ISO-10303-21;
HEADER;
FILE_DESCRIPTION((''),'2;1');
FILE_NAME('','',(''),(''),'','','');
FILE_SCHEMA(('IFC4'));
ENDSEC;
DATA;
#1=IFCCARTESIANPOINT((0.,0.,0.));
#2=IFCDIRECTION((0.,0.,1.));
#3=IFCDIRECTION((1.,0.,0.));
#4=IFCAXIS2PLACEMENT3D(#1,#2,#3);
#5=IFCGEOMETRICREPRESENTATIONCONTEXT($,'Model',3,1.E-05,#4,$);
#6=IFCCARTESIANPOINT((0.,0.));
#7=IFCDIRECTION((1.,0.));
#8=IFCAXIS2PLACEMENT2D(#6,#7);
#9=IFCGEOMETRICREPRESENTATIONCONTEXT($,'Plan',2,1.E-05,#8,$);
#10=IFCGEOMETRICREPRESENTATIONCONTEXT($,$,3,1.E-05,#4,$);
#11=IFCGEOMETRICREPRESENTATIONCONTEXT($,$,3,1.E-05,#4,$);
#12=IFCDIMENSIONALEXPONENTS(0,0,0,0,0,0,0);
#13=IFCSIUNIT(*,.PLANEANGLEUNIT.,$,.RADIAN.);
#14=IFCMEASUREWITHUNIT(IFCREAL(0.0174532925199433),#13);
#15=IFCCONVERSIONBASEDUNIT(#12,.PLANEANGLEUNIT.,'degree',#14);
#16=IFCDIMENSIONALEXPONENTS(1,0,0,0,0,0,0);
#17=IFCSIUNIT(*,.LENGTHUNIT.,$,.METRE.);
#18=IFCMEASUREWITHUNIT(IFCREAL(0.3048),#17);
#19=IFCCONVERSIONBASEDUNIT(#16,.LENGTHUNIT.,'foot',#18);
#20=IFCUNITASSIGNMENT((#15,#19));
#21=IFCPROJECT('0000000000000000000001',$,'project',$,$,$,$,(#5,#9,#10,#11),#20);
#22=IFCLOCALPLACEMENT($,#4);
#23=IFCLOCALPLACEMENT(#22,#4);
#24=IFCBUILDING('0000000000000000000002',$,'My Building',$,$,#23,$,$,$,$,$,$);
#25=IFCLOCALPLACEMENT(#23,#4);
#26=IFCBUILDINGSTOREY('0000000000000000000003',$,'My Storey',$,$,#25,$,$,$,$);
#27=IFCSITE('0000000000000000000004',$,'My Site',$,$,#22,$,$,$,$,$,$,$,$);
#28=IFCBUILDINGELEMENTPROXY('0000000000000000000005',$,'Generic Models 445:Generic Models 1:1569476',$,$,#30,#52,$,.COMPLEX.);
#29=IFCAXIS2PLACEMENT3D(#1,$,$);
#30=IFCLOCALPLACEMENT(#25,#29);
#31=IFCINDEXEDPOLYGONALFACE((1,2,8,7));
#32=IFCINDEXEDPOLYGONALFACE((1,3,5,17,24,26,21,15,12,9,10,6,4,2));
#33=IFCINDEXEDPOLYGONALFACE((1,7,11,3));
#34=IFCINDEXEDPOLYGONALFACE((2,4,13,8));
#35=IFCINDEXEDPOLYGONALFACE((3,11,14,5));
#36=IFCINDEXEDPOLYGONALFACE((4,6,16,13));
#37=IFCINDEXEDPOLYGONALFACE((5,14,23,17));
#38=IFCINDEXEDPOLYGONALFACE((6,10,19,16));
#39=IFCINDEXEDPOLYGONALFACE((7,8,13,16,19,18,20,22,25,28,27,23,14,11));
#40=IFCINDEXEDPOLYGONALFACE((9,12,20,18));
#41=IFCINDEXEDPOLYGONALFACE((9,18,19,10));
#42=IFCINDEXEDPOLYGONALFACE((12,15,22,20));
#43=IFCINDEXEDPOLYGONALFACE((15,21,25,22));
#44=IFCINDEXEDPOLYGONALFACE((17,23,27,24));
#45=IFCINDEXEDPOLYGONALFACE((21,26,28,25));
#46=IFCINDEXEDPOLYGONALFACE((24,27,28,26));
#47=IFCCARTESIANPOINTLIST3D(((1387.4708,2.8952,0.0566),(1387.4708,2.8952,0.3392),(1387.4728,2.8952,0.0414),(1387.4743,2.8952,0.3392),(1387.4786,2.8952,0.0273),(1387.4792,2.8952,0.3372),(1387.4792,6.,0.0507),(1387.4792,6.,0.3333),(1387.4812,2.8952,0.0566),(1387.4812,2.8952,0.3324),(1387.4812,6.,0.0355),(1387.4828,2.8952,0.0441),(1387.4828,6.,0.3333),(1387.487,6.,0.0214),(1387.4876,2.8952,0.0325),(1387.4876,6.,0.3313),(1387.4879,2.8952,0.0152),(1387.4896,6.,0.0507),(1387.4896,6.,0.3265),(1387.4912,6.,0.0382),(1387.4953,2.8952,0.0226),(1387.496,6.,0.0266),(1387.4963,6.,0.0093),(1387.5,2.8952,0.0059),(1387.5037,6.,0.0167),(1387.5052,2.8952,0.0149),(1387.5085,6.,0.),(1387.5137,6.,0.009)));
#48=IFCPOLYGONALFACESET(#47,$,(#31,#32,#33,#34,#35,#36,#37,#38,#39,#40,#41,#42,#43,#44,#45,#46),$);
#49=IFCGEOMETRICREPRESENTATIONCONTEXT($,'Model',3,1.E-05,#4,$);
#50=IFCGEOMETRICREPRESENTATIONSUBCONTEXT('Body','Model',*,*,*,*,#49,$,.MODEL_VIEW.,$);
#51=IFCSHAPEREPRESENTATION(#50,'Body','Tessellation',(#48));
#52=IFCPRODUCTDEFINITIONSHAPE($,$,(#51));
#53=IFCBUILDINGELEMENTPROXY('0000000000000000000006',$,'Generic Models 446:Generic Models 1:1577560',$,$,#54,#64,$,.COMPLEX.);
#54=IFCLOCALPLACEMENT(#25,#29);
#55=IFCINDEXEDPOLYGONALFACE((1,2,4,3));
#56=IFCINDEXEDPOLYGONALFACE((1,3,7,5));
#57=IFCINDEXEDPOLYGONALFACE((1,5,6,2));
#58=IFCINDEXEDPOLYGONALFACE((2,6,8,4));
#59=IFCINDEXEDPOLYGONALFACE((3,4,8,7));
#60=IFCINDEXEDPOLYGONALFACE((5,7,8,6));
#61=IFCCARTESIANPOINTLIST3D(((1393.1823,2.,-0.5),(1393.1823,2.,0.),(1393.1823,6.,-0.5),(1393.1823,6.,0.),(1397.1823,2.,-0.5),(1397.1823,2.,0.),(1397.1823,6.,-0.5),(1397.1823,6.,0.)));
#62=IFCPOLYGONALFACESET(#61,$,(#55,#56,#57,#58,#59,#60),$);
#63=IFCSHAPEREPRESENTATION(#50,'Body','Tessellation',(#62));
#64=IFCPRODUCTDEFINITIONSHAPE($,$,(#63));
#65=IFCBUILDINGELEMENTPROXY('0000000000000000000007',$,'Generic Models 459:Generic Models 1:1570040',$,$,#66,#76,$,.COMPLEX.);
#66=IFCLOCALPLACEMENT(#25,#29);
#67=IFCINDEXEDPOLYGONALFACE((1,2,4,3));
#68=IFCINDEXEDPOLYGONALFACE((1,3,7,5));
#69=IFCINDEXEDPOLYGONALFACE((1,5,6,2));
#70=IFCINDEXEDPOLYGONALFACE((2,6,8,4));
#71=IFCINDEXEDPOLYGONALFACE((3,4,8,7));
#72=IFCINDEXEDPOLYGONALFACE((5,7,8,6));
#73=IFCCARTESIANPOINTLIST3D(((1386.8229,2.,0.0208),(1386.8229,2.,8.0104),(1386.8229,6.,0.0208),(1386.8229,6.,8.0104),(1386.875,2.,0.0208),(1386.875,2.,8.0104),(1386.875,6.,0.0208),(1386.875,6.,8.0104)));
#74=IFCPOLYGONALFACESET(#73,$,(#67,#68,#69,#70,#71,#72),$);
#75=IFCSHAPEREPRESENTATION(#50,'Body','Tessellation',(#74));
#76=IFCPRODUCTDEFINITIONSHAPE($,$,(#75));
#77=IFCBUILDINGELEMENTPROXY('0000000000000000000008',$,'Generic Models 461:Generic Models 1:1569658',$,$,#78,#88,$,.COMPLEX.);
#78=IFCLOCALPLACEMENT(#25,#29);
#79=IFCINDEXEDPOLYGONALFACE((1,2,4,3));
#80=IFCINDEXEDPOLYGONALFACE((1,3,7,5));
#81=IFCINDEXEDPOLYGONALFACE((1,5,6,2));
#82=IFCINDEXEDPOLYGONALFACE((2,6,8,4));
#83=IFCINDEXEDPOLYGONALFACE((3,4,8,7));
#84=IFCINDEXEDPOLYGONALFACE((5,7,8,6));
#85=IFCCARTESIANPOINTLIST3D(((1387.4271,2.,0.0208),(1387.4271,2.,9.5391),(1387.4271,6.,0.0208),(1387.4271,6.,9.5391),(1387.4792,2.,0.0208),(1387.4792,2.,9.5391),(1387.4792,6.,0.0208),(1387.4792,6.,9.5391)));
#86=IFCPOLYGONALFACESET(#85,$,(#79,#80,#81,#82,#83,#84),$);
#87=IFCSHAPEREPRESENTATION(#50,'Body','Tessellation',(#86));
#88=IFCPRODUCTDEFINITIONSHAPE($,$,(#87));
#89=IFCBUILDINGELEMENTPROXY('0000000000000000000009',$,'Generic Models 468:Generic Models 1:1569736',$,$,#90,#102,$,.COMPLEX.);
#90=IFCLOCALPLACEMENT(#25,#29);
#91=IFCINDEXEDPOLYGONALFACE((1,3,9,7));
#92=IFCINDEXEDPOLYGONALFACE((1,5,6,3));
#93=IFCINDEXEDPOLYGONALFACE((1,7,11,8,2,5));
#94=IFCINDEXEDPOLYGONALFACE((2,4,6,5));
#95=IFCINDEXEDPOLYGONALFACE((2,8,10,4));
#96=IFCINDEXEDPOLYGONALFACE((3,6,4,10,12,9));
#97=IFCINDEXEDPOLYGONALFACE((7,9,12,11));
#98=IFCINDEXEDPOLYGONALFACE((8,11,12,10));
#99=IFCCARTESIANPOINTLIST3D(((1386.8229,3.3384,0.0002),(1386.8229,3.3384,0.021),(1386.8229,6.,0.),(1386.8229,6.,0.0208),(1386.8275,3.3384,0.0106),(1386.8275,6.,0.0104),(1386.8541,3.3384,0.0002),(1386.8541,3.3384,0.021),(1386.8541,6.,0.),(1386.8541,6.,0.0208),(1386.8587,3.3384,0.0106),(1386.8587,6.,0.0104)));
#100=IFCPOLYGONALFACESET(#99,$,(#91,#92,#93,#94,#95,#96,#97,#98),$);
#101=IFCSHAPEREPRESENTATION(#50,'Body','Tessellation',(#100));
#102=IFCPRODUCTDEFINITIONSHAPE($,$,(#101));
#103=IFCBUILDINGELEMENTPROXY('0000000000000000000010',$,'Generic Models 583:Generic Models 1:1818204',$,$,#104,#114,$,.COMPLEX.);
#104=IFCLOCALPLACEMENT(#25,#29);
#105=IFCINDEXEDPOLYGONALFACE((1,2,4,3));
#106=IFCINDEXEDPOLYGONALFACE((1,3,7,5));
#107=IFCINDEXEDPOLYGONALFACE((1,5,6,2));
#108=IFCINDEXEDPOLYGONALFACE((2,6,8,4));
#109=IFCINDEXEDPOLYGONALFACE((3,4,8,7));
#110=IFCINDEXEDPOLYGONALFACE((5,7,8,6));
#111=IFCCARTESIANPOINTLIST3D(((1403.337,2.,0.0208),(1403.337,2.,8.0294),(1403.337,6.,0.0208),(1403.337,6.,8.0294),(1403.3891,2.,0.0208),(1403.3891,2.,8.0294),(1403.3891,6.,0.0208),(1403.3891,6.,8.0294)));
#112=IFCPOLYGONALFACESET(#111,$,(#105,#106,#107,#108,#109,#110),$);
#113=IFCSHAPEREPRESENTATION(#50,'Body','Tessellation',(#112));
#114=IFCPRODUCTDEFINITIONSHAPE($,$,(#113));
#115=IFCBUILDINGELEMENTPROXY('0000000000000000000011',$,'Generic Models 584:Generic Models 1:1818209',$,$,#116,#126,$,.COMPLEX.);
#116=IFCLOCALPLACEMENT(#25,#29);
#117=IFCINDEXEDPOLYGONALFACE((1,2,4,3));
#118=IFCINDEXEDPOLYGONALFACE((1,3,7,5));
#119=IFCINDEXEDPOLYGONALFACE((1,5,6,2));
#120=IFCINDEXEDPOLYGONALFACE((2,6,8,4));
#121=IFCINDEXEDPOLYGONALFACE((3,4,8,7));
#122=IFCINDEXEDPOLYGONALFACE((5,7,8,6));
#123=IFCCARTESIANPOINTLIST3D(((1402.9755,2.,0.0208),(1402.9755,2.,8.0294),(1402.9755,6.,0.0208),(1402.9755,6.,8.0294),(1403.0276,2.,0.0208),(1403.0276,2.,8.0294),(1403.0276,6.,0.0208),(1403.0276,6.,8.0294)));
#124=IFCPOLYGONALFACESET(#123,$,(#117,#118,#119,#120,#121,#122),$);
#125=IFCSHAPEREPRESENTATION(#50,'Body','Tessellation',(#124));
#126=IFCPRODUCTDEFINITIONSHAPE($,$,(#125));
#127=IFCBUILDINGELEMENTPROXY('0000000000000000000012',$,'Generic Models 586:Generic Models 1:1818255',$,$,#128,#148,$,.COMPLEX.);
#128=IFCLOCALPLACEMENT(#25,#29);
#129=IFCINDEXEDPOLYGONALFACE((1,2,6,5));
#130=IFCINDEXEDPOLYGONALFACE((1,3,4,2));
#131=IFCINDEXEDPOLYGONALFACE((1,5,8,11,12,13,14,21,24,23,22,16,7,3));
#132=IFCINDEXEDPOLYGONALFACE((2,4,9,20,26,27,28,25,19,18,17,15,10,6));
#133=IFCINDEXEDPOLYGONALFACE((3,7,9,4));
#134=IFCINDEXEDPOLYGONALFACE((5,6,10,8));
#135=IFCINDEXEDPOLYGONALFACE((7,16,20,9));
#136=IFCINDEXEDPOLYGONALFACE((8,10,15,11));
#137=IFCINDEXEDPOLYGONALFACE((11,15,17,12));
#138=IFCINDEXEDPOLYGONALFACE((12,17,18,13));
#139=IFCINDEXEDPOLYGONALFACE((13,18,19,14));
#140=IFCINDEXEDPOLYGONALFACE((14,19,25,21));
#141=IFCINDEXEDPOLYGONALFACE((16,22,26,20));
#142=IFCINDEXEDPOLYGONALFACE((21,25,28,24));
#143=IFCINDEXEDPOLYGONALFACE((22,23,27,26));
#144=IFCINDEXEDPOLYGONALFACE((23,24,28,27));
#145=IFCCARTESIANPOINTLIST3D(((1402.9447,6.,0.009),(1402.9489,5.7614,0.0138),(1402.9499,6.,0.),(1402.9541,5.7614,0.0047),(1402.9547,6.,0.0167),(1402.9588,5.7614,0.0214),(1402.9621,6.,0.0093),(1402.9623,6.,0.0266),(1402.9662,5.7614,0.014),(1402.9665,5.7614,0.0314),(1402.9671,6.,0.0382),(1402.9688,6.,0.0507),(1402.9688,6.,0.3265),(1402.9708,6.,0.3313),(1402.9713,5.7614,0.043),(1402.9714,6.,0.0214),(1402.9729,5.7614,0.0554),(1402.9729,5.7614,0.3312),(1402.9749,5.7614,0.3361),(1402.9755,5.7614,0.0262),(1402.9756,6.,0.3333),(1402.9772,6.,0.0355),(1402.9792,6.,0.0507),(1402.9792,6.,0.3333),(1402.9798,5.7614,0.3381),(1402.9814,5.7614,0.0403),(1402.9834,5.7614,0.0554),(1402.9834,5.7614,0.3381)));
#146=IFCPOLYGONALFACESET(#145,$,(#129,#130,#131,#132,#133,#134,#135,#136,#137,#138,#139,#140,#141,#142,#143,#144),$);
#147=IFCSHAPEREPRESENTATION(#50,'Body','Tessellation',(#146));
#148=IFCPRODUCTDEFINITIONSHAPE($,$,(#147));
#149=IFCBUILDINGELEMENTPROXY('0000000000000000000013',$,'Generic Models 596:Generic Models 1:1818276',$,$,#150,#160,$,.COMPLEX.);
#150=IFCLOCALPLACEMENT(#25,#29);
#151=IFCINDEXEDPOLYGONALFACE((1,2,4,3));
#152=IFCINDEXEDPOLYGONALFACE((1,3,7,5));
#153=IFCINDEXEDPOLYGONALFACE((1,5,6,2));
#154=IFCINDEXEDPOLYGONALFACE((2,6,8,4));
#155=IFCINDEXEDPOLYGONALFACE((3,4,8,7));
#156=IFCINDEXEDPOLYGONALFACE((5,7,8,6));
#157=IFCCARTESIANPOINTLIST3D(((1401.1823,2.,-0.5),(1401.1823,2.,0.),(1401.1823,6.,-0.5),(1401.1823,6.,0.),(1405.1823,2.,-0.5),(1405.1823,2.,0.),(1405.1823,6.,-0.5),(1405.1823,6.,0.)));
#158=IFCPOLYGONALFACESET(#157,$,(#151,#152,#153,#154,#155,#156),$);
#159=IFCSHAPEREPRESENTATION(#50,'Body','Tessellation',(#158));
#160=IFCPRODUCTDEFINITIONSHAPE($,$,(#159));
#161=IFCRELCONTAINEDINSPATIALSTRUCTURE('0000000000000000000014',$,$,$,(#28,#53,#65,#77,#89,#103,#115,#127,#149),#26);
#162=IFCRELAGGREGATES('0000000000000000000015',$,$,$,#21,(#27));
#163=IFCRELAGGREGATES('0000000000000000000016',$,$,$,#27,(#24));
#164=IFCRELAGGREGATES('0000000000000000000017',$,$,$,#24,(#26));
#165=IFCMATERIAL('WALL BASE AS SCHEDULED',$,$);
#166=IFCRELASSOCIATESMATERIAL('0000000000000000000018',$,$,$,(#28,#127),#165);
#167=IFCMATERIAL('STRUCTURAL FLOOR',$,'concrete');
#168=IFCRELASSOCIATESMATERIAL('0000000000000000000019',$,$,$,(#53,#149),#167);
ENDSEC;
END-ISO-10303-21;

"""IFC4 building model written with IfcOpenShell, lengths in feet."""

from ifc_helpers import new_model, entity, si_unit, converted_unit, frame, origin_with_axes, origin_2d_with_axis, place, context, subcontext, project, spatial, polyline, line, indexed_curve, outline, extrude, material, element, save


model = new_model("IFC4")

# Units and contexts
model_context_1 = context("Model", 3, precision=1e-05, world=origin_with_axes())
plan_context = context("Plan", 2, precision=1e-05, world=origin_2d_with_axis())
model_context_2 = context("Model", 3, precision=1e-05, world=origin_with_axes())
context_of_model_1 = context(None, 3, precision=1e-05, world=origin_with_axes())
context_of_model_2 = context(None, 3, precision=1e-05, world=origin_with_axes())
body_context_1 = subcontext(model_context_2, "Body", "Model", "MODEL_VIEW")
ifc_project = project(units=[converted_unit("PLANEANGLEUNIT", "degree", entity("IfcReal", 0.0174532925199433), si_unit("PLANEANGLEUNIT", "RADIAN"), dimensions=[0, 0, 0, 0, 0, 0, 0]), converted_unit("LENGTHUNIT", "foot", entity("IfcReal", 0.3048), si_unit("LENGTHUNIT", "METRE"), dimensions=[1, 0, 0, 0, 0, 0, 0])], contexts=[model_context_1, plan_context, context_of_model_1, context_of_model_2])

# Site, building, storey
site_placement = place(None, origin_with_axes())
site = spatial("IfcSite", under=ifc_project, at=site_placement, Name="My Site")
building_placement = place(site_placement, origin_with_axes())
building = spatial("IfcBuilding", under=site, at=building_placement, Name="My Building")
storey_placement = place(building_placement, origin_with_axes())
storey = spatial("IfcBuildingStorey", under=building, at=storey_placement, Name="My Storey")

# Building element proxies
ifc_material_1 = material(Name="WALL BASE AS SCHEDULED")
ifc_material_2 = material(Name="STRUCTURAL FLOOR", Category="concrete")
proxy_1_placement = place(storey_placement, frame((1387.4792, 6.0, 0.0), z_axis=(0.0, -1.0, 0.0), x_axis=(0.0, 0.0, 1.0)))
element("IfcBuildingElementProxy", 1, at=proxy_1_placement, inside=storey, material=ifc_material_1, Name="Generic Models 445:Generic Models 1:1569476", PredefinedType="COMPLEX", context=body_context_1, shape_type="SweptSolid", body=[
    extrude(outline(polyline([(0.2206, 0.0), (0.2204, 0.0036), (0.2182, 0.0083), (0.2132, 0.01), (-0.0621, -0.0058), (-0.0747, -0.0049), (-0.0865, -0.0007), (-0.0969, 0.0063), (-0.1051, 0.0158), (-0.1138, 0.0101), (-0.1038, -0.0014), (-0.0912, -0.01), (-0.0768, -0.0151), (-0.0615, -0.0162), (0.2206, 0.0)])), frame((0.113, -0.0126, 0.0), z_axis=(0.0, 0.0, -1.0), x_axis=(0.998358, 0.057286, 0.0)), (0.002054, -0.002598, -0.999995), 3.1048),
])
proxy_2_placement = place(storey_placement, frame((1393.1823, 6.0, -0.5), z_axis=(0.0, -1.0, 0.0), x_axis=(0.0, 0.0, 1.0)))
element("IfcBuildingElementProxy", 2, at=proxy_2_placement, inside=storey, material=ifc_material_2, Name="Generic Models 446:Generic Models 1:1577560", PredefinedType="COMPLEX", context=body_context_1, shape_type="SweptSolid", body=[
    extrude(outline(polyline([(-2.0, -0.25), (2.0, -0.25), (2.0, 0.25), (-2.0, 0.25), (-2.0, -0.25)])), frame((0.25, -2.0, 0.0), z_axis=(0.0, 0.0, -1.0), x_axis=(0.0, 1.0, 0.0)), (0.0, 0.0, -1.0), 4.0),
])
proxy_3_placement = place(storey_placement, frame((1386.8229, 6.0, 0.0208), z_axis=(0.0, -1.0, 0.0), x_axis=(0.0, 0.0, 1.0)))
element("IfcBuildingElementProxy", 3, at=proxy_3_placement, inside=storey, Name="Generic Models 459:Generic Models 1:1570040", PredefinedType="COMPLEX", context=body_context_1, shape_type="SweptSolid", body=[
    extrude(outline(polyline([(-3.9948, -0.026), (3.9948, -0.026), (3.9948, 0.026), (-3.9948, 0.026), (-3.9948, -0.026)])), frame((3.9948, -0.026, 0.0), z_axis=(0.0, 0.0, -1.0), x_axis=(-1.0, 0.0, 0.0)), (0.0, 0.0, -1.0), 4.0),
])
proxy_4_placement = place(storey_placement, frame((1387.4271, 6.0, 0.0208), z_axis=(0.0, -1.0, 0.0), x_axis=(0.0, 0.0, 1.0)))
element("IfcBuildingElementProxy", 4, at=proxy_4_placement, inside=storey, Name="Generic Models 461:Generic Models 1:1569658", PredefinedType="COMPLEX", context=body_context_1, shape_type="SweptSolid", body=[
    extrude(outline(polyline([(-4.7591, -0.026), (4.7591, -0.026), (4.7591, 0.026), (-4.7591, 0.026), (-4.7591, -0.026)])), frame((4.7591, -0.026, 0.0), z_axis=(0.0, 0.0, -1.0), x_axis=(-1.0, 0.0, 0.0)), (0.0, 0.0, -1.0), 4.0),
])
proxy_5_placement = place(storey_placement, frame((1386.8229, 6.0, 0.0), z_axis=(0.0, -1.0, 0.0), x_axis=(0.0, 0.0, 1.0)))
element("IfcBuildingElementProxy", 5, at=proxy_5_placement, inside=storey, Name="Generic Models 468:Generic Models 1:1569736", PredefinedType="COMPLEX", context=body_context_1, shape_type="SweptSolid", body=[
    extrude(outline(polyline([(0.0201, 0.0), (-0.0066, 0.0162), (-0.016, 0.0097), (-0.0175, -0.0016), (0.0093, -0.0178), (0.0107, -0.0065), (0.0201, 0.0)])), frame((0.0104, -0.0172, 0.0), z_axis=(0.0, 0.0, -1.0), x_axis=(0.51911, 0.854708, 0.0)), (0.000035, 0.000056, -1.0), 2.6616),
])
proxy_6_placement = place(storey_placement, frame((1403.337, 6.0, 0.0208), z_axis=(0.0, -1.0, 0.0), x_axis=(0.0, 0.0, 1.0)))
element("IfcBuildingElementProxy", 6, at=proxy_6_placement, inside=storey, Name="Generic Models 583:Generic Models 1:1818204", PredefinedType="COMPLEX", context=body_context_1, shape_type="SweptSolid", body=[
    extrude(outline(indexed_curve([(4.0043, 0.026), (4.0043, -0.026), (-4.0043, -0.026), (-4.0043, 0.026)], segments=[line(4, 1), line(1, 2), line(2, 3), line(3, 4)], self_intersect=False)), frame((4.0043, -0.026, 0.0), z_axis=(0.0, 0.0, -1.0), x_axis=(-1.0, 0.0, 0.0)), (0.0, 0.0, -1.0), 4.0),
])
proxy_7_placement = place(storey_placement, frame((1402.9755, 6.0, 0.0208), z_axis=(0.0, -1.0, 0.0), x_axis=(0.0, 0.0, 1.0)))
element("IfcBuildingElementProxy", 7, at=proxy_7_placement, inside=storey, Name="Generic Models 584:Generic Models 1:1818209", PredefinedType="COMPLEX", context=body_context_1, shape_type="SweptSolid", body=[
    extrude(outline(polyline([(-0.026, -4.0043), (0.026, -4.0043), (0.026, 4.0043), (-0.026, 4.0043), (-0.026, -4.0043)])), frame((4.0043, -0.026, 0.0), z_axis=(0.0, 0.0, -1.0), x_axis=(0.0, 1.0, 0.0)), (0.0, 0.0, -1.0), 4.0),
])
proxy_8_placement = place(storey_placement, frame((1402.9447, 6.0, 0.0), z_axis=(0.0, -1.0, 0.0), x_axis=(0.0, 0.0, 1.0)))
element("IfcBuildingElementProxy", 8, at=proxy_8_placement, inside=storey, material=ifc_material_1, Name="Generic Models 586:Generic Models 1:1818255", PredefinedType="COMPLEX", context=body_context_1, shape_type="SweptSolid", body=[
    extrude(outline(polyline([(0.0748, 0.0), (0.0624, -0.0017), (-0.2134, -0.0039), (-0.2182, -0.0059), (-0.2202, -0.0108), (-0.2202, -0.0144), (0.0625, -0.0122), (0.0776, -0.01), (0.0917, -0.0041), (0.1037, 0.0053), (0.1129, 0.0175), (0.1039, 0.0226), (0.0963, 0.0126), (0.0864, 0.0049), (0.0748, 0.0)])), frame((0.113, -0.0218, 0.0), z_axis=(0.0, 0.0, -1.0), x_axis=(-0.99997, -0.007803, 0.0)), (-0.019684, -0.017536, -0.999652), 0.2387),
])
proxy_9_placement = place(storey_placement, frame((1401.1823, 6.0, -0.5), z_axis=(0.0, -1.0, 0.0), x_axis=(0.0, 0.0, 1.0)))
element("IfcBuildingElementProxy", 9, at=proxy_9_placement, inside=storey, material=ifc_material_2, Name="Generic Models 596:Generic Models 1:1818276", PredefinedType="COMPLEX", context=body_context_1, shape_type="SweptSolid", body=[
    extrude(outline(polyline([(-0.25, -2.0), (0.25, -2.0), (0.25, 2.0), (-0.25, 2.0), (-0.25, -2.0)])), frame((0.25, -2.0, 0.0), z_axis=(0.0, 0.0, -1.0), x_axis=(-1.0, 0.0, 0.0)), (0.0, 0.0, -1.0), 4.0),
])

save(model, "model.ifc")
